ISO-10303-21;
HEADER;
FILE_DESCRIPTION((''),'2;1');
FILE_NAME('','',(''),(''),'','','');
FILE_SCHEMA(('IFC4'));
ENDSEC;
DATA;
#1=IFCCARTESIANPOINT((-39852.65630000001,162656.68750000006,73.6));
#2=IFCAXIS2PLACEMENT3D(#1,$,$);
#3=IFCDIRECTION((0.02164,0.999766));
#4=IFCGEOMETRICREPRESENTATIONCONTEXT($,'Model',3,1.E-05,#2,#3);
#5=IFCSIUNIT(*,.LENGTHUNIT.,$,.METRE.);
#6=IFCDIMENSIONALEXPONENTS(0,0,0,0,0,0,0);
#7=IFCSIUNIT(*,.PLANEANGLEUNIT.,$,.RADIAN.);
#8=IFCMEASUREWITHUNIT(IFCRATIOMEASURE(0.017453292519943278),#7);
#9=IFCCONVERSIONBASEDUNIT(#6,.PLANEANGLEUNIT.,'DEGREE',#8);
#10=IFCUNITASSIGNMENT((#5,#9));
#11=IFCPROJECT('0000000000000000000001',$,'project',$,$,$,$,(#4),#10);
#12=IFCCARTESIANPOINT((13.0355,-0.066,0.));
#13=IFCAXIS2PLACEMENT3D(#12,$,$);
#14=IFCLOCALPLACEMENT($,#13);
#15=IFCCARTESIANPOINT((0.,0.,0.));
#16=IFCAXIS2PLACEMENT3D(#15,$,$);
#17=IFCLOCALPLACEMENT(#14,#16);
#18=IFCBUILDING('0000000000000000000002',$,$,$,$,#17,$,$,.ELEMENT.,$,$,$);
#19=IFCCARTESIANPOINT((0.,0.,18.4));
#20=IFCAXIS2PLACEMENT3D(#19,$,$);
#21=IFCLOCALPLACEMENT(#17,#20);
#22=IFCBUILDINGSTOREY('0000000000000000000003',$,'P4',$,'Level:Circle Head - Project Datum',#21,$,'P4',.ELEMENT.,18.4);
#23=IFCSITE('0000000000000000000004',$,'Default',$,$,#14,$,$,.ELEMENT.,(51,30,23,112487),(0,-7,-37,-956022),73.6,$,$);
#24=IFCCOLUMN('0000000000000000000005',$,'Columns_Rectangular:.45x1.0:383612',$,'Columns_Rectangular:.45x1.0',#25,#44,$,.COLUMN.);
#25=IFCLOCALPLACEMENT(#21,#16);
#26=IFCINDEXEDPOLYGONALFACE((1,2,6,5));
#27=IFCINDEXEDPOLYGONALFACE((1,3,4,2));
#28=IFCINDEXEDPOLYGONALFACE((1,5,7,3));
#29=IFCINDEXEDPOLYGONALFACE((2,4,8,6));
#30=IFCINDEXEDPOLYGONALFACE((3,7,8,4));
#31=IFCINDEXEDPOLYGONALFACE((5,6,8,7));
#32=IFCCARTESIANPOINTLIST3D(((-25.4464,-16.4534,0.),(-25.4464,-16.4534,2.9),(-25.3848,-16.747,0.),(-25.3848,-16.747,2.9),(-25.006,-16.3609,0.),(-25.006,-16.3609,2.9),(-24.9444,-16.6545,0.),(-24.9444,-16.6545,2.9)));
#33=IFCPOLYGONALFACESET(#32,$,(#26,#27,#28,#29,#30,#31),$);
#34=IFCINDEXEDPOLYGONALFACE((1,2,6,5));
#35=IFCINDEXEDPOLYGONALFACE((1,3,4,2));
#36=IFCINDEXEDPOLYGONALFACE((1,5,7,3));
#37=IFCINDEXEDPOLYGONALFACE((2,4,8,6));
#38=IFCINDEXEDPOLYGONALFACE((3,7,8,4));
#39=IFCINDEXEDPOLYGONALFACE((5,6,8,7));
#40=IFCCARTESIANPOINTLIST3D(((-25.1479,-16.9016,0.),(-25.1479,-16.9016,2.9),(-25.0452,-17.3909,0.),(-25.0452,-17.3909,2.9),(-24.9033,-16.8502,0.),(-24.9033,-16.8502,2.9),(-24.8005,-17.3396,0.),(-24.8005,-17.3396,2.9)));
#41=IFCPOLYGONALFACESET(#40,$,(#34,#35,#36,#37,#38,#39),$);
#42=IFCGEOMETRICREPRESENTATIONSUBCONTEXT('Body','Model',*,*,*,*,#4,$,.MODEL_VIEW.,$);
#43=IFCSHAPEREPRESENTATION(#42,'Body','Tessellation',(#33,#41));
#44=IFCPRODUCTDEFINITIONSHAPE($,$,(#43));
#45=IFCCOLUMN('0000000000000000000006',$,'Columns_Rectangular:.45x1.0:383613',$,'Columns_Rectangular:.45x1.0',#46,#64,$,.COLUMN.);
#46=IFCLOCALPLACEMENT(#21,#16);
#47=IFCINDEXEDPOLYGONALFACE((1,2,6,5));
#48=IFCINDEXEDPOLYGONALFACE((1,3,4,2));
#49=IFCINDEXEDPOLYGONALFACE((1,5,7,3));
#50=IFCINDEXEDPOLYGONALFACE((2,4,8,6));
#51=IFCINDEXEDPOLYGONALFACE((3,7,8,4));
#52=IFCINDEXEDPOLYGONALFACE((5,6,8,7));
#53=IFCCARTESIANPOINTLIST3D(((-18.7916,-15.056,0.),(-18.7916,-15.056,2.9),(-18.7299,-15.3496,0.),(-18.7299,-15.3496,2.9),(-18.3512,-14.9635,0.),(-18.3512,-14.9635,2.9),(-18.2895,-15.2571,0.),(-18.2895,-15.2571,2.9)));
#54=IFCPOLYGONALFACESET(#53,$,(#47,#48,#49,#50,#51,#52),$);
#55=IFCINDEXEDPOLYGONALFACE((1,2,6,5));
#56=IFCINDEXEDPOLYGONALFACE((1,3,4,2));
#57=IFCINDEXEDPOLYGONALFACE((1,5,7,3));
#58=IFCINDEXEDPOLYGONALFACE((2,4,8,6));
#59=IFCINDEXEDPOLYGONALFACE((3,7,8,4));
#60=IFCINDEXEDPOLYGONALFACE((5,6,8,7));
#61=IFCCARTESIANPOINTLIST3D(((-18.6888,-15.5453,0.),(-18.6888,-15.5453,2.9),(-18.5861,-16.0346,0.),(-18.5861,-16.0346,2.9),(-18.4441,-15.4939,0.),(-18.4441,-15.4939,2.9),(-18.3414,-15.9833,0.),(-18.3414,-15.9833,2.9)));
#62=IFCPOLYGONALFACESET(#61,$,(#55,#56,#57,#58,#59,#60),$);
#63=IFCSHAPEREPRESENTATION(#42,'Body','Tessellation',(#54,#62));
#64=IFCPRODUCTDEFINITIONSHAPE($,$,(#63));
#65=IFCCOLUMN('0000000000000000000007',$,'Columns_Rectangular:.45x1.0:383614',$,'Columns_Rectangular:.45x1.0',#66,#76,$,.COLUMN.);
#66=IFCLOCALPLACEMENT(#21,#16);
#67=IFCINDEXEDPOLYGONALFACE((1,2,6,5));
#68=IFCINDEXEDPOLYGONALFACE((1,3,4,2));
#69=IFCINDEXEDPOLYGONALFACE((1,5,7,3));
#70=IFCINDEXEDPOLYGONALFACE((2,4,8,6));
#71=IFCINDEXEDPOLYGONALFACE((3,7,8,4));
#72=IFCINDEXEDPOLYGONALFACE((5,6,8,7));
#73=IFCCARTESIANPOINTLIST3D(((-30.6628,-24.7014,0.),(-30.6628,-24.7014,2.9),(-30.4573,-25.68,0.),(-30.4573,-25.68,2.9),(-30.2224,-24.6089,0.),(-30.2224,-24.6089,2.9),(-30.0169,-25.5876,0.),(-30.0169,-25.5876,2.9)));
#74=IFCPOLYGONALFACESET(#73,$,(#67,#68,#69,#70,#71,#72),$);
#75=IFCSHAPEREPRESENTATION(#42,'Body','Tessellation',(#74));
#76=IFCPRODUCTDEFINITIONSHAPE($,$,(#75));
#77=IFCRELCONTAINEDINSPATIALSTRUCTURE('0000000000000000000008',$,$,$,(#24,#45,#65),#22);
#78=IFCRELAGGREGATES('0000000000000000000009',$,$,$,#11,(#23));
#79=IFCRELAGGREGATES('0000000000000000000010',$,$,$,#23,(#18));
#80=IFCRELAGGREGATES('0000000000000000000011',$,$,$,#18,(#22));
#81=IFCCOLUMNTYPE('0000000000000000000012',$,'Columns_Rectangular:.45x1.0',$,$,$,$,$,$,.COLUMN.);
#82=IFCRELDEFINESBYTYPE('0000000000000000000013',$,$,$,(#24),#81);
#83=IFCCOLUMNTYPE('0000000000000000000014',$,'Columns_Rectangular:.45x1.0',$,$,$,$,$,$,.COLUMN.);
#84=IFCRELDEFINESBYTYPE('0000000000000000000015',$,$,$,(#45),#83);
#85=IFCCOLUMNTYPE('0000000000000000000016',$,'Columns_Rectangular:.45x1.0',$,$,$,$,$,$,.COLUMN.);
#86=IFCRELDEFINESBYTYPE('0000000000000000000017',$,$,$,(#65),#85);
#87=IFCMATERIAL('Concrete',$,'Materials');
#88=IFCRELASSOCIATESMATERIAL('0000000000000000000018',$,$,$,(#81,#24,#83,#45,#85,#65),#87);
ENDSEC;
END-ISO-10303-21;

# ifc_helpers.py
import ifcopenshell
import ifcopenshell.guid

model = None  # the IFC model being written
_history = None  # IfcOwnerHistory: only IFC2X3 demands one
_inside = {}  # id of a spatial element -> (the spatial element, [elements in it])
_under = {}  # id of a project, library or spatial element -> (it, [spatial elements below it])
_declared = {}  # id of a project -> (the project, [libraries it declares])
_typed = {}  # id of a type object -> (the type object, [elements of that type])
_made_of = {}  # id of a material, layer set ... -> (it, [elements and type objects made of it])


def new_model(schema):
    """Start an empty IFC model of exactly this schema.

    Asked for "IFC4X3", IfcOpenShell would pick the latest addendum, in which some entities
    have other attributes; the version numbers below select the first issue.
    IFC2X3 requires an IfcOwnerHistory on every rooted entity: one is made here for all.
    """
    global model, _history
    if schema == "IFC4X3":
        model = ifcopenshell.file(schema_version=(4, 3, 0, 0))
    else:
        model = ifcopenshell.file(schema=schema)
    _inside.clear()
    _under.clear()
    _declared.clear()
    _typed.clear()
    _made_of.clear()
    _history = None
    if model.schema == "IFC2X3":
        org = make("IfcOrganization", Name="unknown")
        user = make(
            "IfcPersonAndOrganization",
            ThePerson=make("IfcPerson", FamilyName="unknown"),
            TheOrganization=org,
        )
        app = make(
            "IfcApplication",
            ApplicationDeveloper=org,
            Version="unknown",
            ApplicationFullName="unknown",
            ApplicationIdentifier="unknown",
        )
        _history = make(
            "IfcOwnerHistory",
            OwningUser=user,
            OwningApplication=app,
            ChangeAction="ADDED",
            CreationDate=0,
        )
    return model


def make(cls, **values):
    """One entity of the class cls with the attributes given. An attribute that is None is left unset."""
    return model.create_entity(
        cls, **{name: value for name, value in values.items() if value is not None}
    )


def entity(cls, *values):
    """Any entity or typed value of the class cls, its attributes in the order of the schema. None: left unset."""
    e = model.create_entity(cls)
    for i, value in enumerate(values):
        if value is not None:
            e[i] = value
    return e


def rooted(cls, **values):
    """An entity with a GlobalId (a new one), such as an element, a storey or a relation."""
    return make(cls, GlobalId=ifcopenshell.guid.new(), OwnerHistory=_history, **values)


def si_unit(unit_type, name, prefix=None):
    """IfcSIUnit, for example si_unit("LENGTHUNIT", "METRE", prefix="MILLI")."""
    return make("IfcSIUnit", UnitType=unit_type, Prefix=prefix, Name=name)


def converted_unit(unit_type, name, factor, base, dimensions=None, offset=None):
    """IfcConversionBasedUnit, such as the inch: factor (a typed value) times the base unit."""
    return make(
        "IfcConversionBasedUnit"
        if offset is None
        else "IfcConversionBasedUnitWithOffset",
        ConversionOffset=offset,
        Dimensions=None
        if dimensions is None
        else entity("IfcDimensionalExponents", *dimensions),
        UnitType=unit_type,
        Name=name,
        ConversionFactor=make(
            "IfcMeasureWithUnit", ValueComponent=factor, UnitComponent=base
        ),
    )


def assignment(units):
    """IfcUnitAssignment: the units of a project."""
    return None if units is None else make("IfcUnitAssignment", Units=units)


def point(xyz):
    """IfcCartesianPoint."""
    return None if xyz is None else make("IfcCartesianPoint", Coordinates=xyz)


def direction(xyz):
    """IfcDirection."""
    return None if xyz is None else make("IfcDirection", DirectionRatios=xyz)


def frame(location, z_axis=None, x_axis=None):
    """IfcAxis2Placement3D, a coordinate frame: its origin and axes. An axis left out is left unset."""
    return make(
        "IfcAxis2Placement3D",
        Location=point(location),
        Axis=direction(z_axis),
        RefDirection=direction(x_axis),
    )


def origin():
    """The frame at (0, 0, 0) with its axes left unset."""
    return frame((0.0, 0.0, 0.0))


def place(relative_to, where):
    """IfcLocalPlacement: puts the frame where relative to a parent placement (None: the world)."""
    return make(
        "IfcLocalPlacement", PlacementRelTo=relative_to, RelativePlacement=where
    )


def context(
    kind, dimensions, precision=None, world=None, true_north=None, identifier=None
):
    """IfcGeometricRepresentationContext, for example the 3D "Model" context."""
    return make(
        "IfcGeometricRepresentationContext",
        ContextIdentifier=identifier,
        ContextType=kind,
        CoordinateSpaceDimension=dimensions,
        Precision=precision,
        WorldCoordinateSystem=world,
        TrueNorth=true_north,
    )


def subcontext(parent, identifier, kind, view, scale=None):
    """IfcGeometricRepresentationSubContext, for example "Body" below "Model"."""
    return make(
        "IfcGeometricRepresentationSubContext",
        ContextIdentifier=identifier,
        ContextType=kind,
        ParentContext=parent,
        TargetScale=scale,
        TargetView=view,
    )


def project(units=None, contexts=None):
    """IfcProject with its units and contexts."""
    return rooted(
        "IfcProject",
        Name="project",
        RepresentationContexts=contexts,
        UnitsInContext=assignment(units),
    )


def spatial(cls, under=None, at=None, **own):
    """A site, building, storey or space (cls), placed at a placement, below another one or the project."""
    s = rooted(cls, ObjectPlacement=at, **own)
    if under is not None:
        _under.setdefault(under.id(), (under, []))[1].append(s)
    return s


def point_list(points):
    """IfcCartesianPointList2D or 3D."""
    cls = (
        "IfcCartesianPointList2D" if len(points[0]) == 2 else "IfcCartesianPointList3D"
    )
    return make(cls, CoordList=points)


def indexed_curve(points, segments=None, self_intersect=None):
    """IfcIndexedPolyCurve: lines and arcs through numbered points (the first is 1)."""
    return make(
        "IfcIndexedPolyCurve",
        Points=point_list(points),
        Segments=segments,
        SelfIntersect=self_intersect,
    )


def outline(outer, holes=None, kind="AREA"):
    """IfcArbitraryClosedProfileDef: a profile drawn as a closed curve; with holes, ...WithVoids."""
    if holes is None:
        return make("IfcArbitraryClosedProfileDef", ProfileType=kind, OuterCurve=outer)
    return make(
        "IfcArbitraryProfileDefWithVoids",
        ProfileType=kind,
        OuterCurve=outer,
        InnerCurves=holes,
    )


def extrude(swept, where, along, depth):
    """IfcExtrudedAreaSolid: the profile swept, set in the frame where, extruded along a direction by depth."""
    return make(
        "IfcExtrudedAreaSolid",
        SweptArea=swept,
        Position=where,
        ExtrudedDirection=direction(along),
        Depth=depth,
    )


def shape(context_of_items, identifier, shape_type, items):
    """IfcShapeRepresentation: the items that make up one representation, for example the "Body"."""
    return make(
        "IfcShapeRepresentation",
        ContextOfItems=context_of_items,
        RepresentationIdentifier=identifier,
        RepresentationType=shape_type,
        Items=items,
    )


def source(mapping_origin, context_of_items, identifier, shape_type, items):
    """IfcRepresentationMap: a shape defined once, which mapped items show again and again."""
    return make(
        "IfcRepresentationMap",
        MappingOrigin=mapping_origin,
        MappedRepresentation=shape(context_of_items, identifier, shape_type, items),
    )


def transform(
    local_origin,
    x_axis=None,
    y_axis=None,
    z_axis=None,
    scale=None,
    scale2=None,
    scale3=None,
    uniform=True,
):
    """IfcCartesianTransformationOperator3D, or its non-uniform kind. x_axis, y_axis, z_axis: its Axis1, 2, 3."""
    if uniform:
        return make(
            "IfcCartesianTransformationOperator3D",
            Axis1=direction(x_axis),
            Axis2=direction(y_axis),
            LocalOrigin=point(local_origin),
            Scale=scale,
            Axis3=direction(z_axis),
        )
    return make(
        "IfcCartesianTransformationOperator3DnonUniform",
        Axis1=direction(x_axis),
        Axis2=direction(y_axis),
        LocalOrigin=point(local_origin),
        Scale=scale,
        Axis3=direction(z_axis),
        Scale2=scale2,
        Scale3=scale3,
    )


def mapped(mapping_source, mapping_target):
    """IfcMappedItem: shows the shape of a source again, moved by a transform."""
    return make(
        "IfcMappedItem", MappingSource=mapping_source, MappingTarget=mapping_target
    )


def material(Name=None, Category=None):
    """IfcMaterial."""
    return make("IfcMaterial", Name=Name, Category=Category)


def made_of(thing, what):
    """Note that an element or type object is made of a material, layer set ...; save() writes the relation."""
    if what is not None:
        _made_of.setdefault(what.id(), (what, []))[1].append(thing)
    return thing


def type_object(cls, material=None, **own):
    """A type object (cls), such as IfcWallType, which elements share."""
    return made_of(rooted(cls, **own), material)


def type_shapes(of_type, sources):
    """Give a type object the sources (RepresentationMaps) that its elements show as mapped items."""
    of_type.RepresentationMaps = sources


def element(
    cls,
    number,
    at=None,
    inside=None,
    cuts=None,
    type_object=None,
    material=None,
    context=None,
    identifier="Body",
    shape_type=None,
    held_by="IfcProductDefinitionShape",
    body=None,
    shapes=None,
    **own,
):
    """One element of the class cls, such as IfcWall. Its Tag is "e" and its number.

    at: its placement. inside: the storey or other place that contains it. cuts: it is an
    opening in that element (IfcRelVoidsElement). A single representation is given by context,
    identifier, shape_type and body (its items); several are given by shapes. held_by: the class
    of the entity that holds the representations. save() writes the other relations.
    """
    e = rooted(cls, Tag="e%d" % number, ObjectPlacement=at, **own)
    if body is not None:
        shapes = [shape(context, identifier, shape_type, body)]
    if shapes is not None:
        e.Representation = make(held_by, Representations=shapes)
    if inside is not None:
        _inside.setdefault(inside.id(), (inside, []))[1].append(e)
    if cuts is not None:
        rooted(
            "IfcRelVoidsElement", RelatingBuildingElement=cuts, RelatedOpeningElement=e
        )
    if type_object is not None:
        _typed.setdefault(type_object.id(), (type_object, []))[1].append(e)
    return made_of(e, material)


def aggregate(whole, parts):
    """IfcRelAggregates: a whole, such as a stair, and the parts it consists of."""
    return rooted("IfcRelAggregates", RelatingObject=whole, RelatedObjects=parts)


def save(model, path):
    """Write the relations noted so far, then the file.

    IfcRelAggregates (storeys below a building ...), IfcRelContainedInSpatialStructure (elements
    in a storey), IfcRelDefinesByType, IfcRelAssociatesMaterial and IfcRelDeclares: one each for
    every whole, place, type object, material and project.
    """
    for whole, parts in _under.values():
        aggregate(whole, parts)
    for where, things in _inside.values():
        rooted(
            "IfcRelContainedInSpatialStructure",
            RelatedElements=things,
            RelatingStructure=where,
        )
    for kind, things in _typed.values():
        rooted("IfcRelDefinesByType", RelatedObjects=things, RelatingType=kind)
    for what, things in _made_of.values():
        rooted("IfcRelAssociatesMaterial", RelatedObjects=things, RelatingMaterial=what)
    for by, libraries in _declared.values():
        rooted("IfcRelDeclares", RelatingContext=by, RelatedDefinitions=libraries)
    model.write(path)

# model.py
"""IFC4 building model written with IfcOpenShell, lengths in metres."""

from ifc_helpers import new_model, entity, si_unit, converted_unit, direction, frame, origin, place, context, subcontext, project, spatial, indexed_curve, outline, extrude, source, transform, mapped, material, type_object, type_shapes, element, save


model = new_model("IFC4")

# Units and contexts
model_context = context("Model", 3, precision=1e-05, world=frame((-39852.65630000001, 162656.68750000006, 73.6)), true_north=direction((0.02164, 0.999766)))
body_context = subcontext(model_context, "Body", "Model", "MODEL_VIEW")
ifc_project = project(units=[si_unit("LENGTHUNIT", "METRE"), converted_unit("PLANEANGLEUNIT", "DEGREE", entity("IfcRatioMeasure", 0.017453292519943278), si_unit("PLANEANGLEUNIT", "RADIAN"), dimensions=[0, 0, 0, 0, 0, 0, 0])], contexts=[model_context])

# Site, building, storey
site_placement = place(None, frame((13.0355, -0.066, 0.0)))
site = spatial("IfcSite", under=ifc_project, at=site_placement, Name="Default", CompositionType="ELEMENT", RefLatitude=(51, 30, 23, 112487), RefLongitude=(0, -7, -37, -956022), RefElevation=73.6)
building_placement = place(site_placement, origin())
building = spatial("IfcBuilding", under=site, at=building_placement, CompositionType="ELEMENT")
storey_placement = place(building_placement, frame((0.0, 0.0, 18.4)))
storey = spatial("IfcBuildingStorey", under=building, at=storey_placement, Name="P4", ObjectType="Level:Circle Head - Project Datum", LongName="P4", CompositionType="ELEMENT", Elevation=18.4)

# Columns
ifc_material = material(Name="Concrete", Category="Materials")
column_type_1 = type_object("IfcColumnType", Name="Columns_Rectangular:.45x1.0", PredefinedType="COLUMN", material=ifc_material)
shared_shape_1 = source(origin(), body_context, "Body", "SweptSolid", [
    extrude(outline(indexed_curve([(-0.225, -0.15), (0.225, -0.15), (0.225, 0.15), (-0.225, 0.15), (-0.225, -0.15)], self_intersect=False)), frame((-25.1954, -16.5539, 18.4), z_axis=(0.0, 0.0, 1.0), x_axis=(-0.978657, -0.2055, 0.0)), (0.0, 0.0, 1.0), 2.9),
    extrude(outline(indexed_curve([(-0.25, -0.125), (0.25, -0.125), (0.25, 0.125), (-0.25, 0.125), (-0.25, -0.125)], self_intersect=False)), frame((-24.9742, -17.1206, 18.4), z_axis=(0.0, 0.0, 1.0), x_axis=(-0.2055, 0.978657, 0.0)), (0.0, 0.0, 1.0), 2.9),
])
type_shapes(column_type_1, [shared_shape_1])
column_1_placement = place(storey_placement, frame((0.0, 0.0, -18.4)))
element("IfcColumn", 1, at=column_1_placement, inside=storey, type_object=column_type_1, material=ifc_material, Name="Columns_Rectangular:.45x1.0:383612", ObjectType="Columns_Rectangular:.45x1.0", PredefinedType="COLUMN", context=body_context, shape_type="MappedRepresentation", body=[
    mapped(shared_shape_1, transform((0.0, 0.0, 0.0), scale=1.0)),
])
column_type_2 = type_object("IfcColumnType", Name="Columns_Rectangular:.45x1.0", PredefinedType="COLUMN", material=ifc_material)
shared_shape_2 = source(origin(), body_context, "Body", "SweptSolid", [
    extrude(outline(indexed_curve([(-0.225, -0.15), (0.225, -0.15), (0.225, 0.15), (-0.225, 0.15), (-0.225, -0.15)], self_intersect=False)), frame((-18.5405, -15.1565, 18.4), z_axis=(0.0, 0.0, 1.0), x_axis=(-0.978657, -0.2055, 0.0)), (0.0, 0.0, 1.0), 2.9),
    extrude(outline(indexed_curve([(-0.25, -0.125), (0.25, -0.125), (0.25, 0.125), (-0.25, 0.125), (-0.25, -0.125)], self_intersect=False)), frame((-18.5151, -15.7643, 18.4), z_axis=(0.0, 0.0, 1.0), x_axis=(-0.2055, 0.978657, 0.0)), (0.0, 0.0, 1.0), 2.9),
])
type_shapes(column_type_2, [shared_shape_2])
column_2_placement = place(storey_placement, frame((0.0, 0.0, -18.4)))
element("IfcColumn", 2, at=column_2_placement, inside=storey, type_object=column_type_2, material=ifc_material, Name="Columns_Rectangular:.45x1.0:383613", ObjectType="Columns_Rectangular:.45x1.0", PredefinedType="COLUMN", context=body_context, shape_type="MappedRepresentation", body=[
    mapped(shared_shape_2, transform((0.0, 0.0, 0.0), scale=1.0)),
])
column_type_3 = type_object("IfcColumnType", Name="Columns_Rectangular:.45x1.0", PredefinedType="COLUMN", material=ifc_material)
shared_shape_3 = source(origin(), body_context, "Body", "SweptSolid", [
    extrude(outline(indexed_curve([(-0.5, -0.225), (0.5, -0.225), (0.5, 0.225), (-0.5, 0.225), (-0.5, -0.225)], self_intersect=False)), frame((-30.3399, -25.1445, 18.4), z_axis=(0.0, 0.0, 1.0), x_axis=(-0.2055, 0.978657, 0.0)), (0.0, 0.0, 1.0), 2.9),
])
type_shapes(column_type_3, [shared_shape_3])
column_3_placement = place(storey_placement, frame((0.0, 0.0, -18.4)))
element("IfcColumn", 3, at=column_3_placement, inside=storey, type_object=column_type_3, material=ifc_material, Name="Columns_Rectangular:.45x1.0:383614", ObjectType="Columns_Rectangular:.45x1.0", PredefinedType="COLUMN", context=body_context, shape_type="MappedRepresentation", body=[
    mapped(shared_shape_3, transform((0.0, 0.0, 0.0), scale=1.0)),
])

save(model, "model.ifc")
